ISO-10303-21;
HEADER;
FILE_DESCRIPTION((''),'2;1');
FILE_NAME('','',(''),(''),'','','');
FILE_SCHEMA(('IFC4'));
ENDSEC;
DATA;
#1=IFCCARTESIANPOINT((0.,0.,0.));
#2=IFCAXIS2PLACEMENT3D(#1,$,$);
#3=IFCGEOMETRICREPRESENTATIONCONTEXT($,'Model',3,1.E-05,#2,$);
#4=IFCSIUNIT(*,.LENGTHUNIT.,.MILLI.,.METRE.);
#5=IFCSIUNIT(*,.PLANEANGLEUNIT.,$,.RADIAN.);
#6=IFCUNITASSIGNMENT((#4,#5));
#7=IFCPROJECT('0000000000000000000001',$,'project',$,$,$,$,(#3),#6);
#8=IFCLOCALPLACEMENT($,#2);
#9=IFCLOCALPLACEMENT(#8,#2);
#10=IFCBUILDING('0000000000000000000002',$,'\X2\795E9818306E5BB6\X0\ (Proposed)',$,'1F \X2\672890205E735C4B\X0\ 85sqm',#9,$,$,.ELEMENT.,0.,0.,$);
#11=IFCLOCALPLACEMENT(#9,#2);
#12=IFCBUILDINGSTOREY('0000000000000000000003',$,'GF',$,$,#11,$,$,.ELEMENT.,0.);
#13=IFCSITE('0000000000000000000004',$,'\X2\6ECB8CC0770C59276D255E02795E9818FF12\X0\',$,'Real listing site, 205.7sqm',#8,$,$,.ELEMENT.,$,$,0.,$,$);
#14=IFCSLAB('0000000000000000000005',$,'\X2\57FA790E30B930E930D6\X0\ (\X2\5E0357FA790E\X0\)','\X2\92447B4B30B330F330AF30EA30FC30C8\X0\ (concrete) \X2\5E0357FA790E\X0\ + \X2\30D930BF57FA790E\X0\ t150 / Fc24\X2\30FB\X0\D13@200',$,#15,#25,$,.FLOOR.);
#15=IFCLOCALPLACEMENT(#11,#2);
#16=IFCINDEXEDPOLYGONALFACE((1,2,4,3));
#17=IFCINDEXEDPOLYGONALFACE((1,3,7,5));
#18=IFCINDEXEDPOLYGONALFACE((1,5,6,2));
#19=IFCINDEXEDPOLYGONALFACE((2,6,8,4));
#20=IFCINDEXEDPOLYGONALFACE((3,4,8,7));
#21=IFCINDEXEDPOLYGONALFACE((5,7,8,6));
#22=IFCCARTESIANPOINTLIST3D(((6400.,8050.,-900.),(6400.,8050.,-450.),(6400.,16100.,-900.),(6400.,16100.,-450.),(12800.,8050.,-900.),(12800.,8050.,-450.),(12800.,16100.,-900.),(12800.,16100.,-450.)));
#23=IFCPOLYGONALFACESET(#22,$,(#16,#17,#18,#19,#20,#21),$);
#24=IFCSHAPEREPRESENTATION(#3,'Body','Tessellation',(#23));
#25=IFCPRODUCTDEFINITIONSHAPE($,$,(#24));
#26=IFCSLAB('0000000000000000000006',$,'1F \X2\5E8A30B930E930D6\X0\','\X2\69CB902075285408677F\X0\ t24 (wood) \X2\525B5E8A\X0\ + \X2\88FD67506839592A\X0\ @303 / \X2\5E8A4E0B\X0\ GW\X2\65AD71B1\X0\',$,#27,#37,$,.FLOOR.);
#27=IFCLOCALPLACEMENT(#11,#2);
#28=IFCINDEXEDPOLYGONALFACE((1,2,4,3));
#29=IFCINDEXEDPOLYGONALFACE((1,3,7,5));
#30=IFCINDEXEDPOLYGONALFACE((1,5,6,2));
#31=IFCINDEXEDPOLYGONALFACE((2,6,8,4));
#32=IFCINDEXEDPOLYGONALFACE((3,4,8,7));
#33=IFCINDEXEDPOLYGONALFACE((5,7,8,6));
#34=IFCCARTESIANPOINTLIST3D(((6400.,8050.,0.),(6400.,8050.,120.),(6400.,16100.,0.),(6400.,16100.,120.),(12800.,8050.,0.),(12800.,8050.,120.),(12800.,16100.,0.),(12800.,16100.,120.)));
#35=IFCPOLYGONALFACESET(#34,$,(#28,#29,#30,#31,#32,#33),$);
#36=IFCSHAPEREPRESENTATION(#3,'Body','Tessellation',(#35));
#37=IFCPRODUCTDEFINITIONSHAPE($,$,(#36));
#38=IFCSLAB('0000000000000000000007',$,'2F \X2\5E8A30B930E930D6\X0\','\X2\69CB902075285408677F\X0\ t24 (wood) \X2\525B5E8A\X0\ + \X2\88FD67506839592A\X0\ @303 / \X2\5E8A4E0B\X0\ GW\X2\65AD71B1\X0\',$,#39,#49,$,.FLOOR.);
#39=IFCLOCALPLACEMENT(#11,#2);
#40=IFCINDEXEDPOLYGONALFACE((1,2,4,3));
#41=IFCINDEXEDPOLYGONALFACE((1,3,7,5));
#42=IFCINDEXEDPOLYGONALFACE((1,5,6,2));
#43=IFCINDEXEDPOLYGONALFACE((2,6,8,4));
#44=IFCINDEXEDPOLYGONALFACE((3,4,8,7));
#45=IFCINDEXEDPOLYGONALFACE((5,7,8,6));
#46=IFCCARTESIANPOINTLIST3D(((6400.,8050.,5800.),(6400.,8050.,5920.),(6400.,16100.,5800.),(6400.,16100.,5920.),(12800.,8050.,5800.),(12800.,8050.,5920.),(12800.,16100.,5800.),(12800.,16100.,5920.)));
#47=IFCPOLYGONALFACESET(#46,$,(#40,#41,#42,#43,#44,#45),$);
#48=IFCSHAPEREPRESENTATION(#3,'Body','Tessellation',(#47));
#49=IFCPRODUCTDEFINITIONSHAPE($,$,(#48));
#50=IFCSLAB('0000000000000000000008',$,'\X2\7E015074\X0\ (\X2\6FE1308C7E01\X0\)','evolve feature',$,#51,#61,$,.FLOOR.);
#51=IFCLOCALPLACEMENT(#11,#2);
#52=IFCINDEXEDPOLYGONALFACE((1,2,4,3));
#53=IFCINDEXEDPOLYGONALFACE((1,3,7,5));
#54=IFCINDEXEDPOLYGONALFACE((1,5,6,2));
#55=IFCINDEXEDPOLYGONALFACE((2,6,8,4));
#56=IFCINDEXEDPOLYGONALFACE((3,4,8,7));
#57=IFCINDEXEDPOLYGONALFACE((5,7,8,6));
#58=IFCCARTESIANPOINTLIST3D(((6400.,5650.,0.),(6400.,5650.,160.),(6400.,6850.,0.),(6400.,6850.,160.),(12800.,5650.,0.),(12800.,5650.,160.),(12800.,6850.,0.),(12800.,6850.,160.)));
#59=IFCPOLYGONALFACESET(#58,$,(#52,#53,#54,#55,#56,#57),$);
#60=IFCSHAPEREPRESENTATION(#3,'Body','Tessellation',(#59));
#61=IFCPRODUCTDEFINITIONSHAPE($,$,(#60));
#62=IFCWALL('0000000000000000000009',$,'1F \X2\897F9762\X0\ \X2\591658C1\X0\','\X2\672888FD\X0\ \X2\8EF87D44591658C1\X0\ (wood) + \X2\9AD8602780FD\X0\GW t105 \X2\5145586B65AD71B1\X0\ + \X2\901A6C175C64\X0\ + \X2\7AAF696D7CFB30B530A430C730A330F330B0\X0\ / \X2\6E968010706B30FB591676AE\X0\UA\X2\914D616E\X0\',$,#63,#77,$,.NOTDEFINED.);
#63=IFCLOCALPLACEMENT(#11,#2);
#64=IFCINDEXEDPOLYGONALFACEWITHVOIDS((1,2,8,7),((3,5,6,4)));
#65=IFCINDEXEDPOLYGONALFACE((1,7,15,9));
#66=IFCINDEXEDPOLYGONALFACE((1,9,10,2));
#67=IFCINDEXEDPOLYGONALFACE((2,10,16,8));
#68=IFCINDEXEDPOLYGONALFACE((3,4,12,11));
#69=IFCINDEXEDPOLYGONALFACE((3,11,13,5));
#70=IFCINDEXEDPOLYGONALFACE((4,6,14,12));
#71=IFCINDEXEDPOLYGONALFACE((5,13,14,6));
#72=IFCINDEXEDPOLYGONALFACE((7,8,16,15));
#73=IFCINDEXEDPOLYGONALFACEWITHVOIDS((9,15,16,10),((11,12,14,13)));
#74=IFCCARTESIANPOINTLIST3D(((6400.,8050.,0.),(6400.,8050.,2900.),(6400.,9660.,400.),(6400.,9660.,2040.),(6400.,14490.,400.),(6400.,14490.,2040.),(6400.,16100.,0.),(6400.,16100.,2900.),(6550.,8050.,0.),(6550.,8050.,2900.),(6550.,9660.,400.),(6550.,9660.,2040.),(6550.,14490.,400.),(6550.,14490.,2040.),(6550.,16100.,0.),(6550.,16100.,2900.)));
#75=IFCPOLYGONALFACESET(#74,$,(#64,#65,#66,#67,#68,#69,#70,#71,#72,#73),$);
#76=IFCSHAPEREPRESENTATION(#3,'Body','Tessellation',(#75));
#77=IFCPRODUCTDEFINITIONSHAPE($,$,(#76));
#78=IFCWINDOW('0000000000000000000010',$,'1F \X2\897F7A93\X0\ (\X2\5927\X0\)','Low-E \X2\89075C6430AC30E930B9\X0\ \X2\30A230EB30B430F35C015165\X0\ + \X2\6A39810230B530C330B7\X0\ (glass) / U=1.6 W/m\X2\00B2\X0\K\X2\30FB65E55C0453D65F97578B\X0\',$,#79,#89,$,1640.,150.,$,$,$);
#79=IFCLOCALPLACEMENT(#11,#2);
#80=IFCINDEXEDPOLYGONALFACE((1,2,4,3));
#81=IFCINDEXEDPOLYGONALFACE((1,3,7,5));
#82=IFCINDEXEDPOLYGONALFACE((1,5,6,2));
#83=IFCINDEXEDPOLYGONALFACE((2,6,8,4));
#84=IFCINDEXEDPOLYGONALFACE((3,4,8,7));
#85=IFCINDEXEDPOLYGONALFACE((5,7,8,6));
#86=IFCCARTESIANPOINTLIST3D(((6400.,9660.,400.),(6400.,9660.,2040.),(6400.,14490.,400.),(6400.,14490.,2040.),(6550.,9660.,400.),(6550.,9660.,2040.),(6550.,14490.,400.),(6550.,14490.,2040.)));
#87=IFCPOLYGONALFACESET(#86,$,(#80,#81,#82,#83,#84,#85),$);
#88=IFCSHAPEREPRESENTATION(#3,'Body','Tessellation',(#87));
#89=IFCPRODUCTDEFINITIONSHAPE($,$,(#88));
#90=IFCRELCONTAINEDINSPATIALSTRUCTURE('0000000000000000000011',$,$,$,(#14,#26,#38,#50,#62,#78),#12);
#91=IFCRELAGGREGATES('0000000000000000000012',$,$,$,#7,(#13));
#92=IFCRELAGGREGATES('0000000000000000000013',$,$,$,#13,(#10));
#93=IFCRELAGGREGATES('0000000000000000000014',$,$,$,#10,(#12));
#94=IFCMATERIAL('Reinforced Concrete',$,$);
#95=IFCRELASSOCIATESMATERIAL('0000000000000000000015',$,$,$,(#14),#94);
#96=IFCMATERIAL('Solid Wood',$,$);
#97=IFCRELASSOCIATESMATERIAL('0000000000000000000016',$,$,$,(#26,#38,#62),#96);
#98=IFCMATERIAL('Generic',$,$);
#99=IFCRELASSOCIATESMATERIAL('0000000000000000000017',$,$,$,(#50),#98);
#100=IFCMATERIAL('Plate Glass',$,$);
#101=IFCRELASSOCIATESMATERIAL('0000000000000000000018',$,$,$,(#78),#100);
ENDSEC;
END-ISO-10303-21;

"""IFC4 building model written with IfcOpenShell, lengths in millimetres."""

from ifc_helpers import new_model, si_unit, frame, frame_2d, origin, place, context, project, spatial, rectangle, extrude, material, element, fill, save


model = new_model("IFC4")

# Units and contexts
model_context = context("Model", 3, precision=1e-05, world=origin())
ifc_project = project(units=[si_unit("LENGTHUNIT", "METRE", prefix="MILLI"), si_unit("PLANEANGLEUNIT", "RADIAN")], contexts=[model_context])

# Site, building, storey
site_placement = place(None, origin())
site = spatial("IfcSite", under=ifc_project, at=site_placement, Name="滋賀県大津市神領２", ObjectType="Real listing site, 205.7sqm", CompositionType="ELEMENT", RefElevation=0.0)
building_placement = place(site_placement, origin())
building = spatial("IfcBuilding", under=site, at=building_placement, Name="神領の家 (Proposed)", ObjectType="1F 木造平屋 85sqm", CompositionType="ELEMENT", ElevationOfRefHeight=0.0, ElevationOfTerrain=0.0)
storey_placement = place(building_placement, origin())
storey = spatial("IfcBuildingStorey", under=building, at=storey_placement, Name="GF", CompositionType="ELEMENT", Elevation=0.0)

# Slabs
ifc_material_1 = material(Name="Reinforced Concrete")
slab_1_placement = place(storey_placement, frame((3200.0, 4025.0, -450.0)))
element("IfcSlab", 1, at=slab_1_placement, inside=storey, material=ifc_material_1, Name="基礎スラブ (布基礎)", Description="鉄筋コンクリート (concrete) 布基礎 + ベタ基礎 t150 / Fc24・D13@200", PredefinedType="FLOOR", context=model_context, shape_type="SweptSolid", body=[
    extrude(rectangle(XDim=6400.0, YDim=8050.0, at=frame_2d((3200.0, 4025.0))), frame((3200.0, 4025.0, -450.0)), (0.0, 0.0, 1.0), 450.0),
])
ifc_material_2 = material(Name="Solid Wood")
slab_2_placement = place(storey_placement, frame((3200.0, 4025.0, 0.0)))
element("IfcSlab", 2, at=slab_2_placement, inside=storey, material=ifc_material_2, Name="1F 床スラブ", Description="構造用合板 t24 (wood) 剛床 + 製材根太 @303 / 床下 GW断熱", PredefinedType="FLOOR", context=model_context, shape_type="SweptSolid", body=[
    extrude(rectangle(XDim=6400.0, YDim=8050.0, at=frame_2d((3200.0, 4025.0))), frame((3200.0, 4025.0, 0.0)), (0.0, 0.0, 1.0), 120.0),
])
slab_3_placement = place(storey_placement, frame((3200.0, 4025.0, 2900.0)))
element("IfcSlab", 3, at=slab_3_placement, inside=storey, material=ifc_material_2, Name="2F 床スラブ", Description="構造用合板 t24 (wood) 剛床 + 製材根太 @303 / 床下 GW断熱", PredefinedType="FLOOR", context=model_context, shape_type="SweptSolid", body=[
    extrude(rectangle(XDim=6400.0, YDim=8050.0, at=frame_2d((3200.0, 4025.0))), frame((3200.0, 4025.0, 2900.0)), (0.0, 0.0, 1.0), 120.0),
])
ifc_material_3 = material(Name="Generic")
slab_4_placement = place(storey_placement, frame((3200.0, 2825.0, 0.0)))
element("IfcSlab", 4, at=slab_4_placement, inside=storey, material=ifc_material_3, Name="縁側 (濡れ縁)", Description="evolve feature", PredefinedType="FLOOR", context=model_context, shape_type="SweptSolid", body=[
    extrude(rectangle(XDim=6400.0, YDim=1200.0, at=frame_2d((3200.0, 600.0))), frame((3200.0, 2825.0, 0.0)), (0.0, 0.0, 1.0), 160.0),
])

# Shared definitions
ifc_material_4 = material(Name="Plate Glass")

# Wall, opening, window
wall_1_placement = place(storey_placement, frame((3200.0, 4025.0, 0.0)))
wall_1 = element("IfcWall", 5, at=wall_1_placement, inside=storey, material=ifc_material_2, Name="1F 西面 外壁", Description="木製 軸組外壁 (wood) + 高性能GW t105 充填断熱 + 通気層 + 窯業系サイディング / 準耐火・外皮UA配慮", PredefinedType="NOTDEFINED", context=model_context, shape_type="SweptSolid", body=[
    extrude(rectangle(XDim=150.0, YDim=8050.0, at=frame_2d((75.0, 4025.0))), frame((3200.0, 4025.0, 0.0)), (0.0, 0.0, 1.0), 2900.0),
])
opening_1_placement = place(storey_placement, frame((3200.0, 4830.0, 200.0)))
opening_1 = element("IfcOpeningElement", 6, at=opening_1_placement, cuts=wall_1, PredefinedType="NOTDEFINED", context=model_context, shape_type="SweptSolid", body=[
    extrude(rectangle(XDim=150.0, YDim=4830.0, at=frame_2d((75.0, 2415.0))), frame((3200.0, 4830.0, 200.0)), (0.0, 0.0, 1.0), 1640.0),
])
window_1_placement = place(storey_placement, frame((3200.0, 4830.0, 200.0)))
window_1 = element("IfcWindow", 7, at=window_1_placement, inside=storey, material=ifc_material_4, Name="1F 西窓 (大)", Description="Low-E 複層ガラス アルゴン封入 + 樹脂サッシ (glass) / U=1.6 W/m²K・日射取得型", OverallHeight=1640.0, OverallWidth=150.0, context=model_context, shape_type="SweptSolid", body=[
    extrude(rectangle(XDim=150.0, YDim=4830.0, at=frame_2d((75.0, 2415.0))), frame((3200.0, 4830.0, 200.0)), (0.0, 0.0, 1.0), 1640.0),
])
fill(opening_1, window_1)

save(model, "model.ifc")
